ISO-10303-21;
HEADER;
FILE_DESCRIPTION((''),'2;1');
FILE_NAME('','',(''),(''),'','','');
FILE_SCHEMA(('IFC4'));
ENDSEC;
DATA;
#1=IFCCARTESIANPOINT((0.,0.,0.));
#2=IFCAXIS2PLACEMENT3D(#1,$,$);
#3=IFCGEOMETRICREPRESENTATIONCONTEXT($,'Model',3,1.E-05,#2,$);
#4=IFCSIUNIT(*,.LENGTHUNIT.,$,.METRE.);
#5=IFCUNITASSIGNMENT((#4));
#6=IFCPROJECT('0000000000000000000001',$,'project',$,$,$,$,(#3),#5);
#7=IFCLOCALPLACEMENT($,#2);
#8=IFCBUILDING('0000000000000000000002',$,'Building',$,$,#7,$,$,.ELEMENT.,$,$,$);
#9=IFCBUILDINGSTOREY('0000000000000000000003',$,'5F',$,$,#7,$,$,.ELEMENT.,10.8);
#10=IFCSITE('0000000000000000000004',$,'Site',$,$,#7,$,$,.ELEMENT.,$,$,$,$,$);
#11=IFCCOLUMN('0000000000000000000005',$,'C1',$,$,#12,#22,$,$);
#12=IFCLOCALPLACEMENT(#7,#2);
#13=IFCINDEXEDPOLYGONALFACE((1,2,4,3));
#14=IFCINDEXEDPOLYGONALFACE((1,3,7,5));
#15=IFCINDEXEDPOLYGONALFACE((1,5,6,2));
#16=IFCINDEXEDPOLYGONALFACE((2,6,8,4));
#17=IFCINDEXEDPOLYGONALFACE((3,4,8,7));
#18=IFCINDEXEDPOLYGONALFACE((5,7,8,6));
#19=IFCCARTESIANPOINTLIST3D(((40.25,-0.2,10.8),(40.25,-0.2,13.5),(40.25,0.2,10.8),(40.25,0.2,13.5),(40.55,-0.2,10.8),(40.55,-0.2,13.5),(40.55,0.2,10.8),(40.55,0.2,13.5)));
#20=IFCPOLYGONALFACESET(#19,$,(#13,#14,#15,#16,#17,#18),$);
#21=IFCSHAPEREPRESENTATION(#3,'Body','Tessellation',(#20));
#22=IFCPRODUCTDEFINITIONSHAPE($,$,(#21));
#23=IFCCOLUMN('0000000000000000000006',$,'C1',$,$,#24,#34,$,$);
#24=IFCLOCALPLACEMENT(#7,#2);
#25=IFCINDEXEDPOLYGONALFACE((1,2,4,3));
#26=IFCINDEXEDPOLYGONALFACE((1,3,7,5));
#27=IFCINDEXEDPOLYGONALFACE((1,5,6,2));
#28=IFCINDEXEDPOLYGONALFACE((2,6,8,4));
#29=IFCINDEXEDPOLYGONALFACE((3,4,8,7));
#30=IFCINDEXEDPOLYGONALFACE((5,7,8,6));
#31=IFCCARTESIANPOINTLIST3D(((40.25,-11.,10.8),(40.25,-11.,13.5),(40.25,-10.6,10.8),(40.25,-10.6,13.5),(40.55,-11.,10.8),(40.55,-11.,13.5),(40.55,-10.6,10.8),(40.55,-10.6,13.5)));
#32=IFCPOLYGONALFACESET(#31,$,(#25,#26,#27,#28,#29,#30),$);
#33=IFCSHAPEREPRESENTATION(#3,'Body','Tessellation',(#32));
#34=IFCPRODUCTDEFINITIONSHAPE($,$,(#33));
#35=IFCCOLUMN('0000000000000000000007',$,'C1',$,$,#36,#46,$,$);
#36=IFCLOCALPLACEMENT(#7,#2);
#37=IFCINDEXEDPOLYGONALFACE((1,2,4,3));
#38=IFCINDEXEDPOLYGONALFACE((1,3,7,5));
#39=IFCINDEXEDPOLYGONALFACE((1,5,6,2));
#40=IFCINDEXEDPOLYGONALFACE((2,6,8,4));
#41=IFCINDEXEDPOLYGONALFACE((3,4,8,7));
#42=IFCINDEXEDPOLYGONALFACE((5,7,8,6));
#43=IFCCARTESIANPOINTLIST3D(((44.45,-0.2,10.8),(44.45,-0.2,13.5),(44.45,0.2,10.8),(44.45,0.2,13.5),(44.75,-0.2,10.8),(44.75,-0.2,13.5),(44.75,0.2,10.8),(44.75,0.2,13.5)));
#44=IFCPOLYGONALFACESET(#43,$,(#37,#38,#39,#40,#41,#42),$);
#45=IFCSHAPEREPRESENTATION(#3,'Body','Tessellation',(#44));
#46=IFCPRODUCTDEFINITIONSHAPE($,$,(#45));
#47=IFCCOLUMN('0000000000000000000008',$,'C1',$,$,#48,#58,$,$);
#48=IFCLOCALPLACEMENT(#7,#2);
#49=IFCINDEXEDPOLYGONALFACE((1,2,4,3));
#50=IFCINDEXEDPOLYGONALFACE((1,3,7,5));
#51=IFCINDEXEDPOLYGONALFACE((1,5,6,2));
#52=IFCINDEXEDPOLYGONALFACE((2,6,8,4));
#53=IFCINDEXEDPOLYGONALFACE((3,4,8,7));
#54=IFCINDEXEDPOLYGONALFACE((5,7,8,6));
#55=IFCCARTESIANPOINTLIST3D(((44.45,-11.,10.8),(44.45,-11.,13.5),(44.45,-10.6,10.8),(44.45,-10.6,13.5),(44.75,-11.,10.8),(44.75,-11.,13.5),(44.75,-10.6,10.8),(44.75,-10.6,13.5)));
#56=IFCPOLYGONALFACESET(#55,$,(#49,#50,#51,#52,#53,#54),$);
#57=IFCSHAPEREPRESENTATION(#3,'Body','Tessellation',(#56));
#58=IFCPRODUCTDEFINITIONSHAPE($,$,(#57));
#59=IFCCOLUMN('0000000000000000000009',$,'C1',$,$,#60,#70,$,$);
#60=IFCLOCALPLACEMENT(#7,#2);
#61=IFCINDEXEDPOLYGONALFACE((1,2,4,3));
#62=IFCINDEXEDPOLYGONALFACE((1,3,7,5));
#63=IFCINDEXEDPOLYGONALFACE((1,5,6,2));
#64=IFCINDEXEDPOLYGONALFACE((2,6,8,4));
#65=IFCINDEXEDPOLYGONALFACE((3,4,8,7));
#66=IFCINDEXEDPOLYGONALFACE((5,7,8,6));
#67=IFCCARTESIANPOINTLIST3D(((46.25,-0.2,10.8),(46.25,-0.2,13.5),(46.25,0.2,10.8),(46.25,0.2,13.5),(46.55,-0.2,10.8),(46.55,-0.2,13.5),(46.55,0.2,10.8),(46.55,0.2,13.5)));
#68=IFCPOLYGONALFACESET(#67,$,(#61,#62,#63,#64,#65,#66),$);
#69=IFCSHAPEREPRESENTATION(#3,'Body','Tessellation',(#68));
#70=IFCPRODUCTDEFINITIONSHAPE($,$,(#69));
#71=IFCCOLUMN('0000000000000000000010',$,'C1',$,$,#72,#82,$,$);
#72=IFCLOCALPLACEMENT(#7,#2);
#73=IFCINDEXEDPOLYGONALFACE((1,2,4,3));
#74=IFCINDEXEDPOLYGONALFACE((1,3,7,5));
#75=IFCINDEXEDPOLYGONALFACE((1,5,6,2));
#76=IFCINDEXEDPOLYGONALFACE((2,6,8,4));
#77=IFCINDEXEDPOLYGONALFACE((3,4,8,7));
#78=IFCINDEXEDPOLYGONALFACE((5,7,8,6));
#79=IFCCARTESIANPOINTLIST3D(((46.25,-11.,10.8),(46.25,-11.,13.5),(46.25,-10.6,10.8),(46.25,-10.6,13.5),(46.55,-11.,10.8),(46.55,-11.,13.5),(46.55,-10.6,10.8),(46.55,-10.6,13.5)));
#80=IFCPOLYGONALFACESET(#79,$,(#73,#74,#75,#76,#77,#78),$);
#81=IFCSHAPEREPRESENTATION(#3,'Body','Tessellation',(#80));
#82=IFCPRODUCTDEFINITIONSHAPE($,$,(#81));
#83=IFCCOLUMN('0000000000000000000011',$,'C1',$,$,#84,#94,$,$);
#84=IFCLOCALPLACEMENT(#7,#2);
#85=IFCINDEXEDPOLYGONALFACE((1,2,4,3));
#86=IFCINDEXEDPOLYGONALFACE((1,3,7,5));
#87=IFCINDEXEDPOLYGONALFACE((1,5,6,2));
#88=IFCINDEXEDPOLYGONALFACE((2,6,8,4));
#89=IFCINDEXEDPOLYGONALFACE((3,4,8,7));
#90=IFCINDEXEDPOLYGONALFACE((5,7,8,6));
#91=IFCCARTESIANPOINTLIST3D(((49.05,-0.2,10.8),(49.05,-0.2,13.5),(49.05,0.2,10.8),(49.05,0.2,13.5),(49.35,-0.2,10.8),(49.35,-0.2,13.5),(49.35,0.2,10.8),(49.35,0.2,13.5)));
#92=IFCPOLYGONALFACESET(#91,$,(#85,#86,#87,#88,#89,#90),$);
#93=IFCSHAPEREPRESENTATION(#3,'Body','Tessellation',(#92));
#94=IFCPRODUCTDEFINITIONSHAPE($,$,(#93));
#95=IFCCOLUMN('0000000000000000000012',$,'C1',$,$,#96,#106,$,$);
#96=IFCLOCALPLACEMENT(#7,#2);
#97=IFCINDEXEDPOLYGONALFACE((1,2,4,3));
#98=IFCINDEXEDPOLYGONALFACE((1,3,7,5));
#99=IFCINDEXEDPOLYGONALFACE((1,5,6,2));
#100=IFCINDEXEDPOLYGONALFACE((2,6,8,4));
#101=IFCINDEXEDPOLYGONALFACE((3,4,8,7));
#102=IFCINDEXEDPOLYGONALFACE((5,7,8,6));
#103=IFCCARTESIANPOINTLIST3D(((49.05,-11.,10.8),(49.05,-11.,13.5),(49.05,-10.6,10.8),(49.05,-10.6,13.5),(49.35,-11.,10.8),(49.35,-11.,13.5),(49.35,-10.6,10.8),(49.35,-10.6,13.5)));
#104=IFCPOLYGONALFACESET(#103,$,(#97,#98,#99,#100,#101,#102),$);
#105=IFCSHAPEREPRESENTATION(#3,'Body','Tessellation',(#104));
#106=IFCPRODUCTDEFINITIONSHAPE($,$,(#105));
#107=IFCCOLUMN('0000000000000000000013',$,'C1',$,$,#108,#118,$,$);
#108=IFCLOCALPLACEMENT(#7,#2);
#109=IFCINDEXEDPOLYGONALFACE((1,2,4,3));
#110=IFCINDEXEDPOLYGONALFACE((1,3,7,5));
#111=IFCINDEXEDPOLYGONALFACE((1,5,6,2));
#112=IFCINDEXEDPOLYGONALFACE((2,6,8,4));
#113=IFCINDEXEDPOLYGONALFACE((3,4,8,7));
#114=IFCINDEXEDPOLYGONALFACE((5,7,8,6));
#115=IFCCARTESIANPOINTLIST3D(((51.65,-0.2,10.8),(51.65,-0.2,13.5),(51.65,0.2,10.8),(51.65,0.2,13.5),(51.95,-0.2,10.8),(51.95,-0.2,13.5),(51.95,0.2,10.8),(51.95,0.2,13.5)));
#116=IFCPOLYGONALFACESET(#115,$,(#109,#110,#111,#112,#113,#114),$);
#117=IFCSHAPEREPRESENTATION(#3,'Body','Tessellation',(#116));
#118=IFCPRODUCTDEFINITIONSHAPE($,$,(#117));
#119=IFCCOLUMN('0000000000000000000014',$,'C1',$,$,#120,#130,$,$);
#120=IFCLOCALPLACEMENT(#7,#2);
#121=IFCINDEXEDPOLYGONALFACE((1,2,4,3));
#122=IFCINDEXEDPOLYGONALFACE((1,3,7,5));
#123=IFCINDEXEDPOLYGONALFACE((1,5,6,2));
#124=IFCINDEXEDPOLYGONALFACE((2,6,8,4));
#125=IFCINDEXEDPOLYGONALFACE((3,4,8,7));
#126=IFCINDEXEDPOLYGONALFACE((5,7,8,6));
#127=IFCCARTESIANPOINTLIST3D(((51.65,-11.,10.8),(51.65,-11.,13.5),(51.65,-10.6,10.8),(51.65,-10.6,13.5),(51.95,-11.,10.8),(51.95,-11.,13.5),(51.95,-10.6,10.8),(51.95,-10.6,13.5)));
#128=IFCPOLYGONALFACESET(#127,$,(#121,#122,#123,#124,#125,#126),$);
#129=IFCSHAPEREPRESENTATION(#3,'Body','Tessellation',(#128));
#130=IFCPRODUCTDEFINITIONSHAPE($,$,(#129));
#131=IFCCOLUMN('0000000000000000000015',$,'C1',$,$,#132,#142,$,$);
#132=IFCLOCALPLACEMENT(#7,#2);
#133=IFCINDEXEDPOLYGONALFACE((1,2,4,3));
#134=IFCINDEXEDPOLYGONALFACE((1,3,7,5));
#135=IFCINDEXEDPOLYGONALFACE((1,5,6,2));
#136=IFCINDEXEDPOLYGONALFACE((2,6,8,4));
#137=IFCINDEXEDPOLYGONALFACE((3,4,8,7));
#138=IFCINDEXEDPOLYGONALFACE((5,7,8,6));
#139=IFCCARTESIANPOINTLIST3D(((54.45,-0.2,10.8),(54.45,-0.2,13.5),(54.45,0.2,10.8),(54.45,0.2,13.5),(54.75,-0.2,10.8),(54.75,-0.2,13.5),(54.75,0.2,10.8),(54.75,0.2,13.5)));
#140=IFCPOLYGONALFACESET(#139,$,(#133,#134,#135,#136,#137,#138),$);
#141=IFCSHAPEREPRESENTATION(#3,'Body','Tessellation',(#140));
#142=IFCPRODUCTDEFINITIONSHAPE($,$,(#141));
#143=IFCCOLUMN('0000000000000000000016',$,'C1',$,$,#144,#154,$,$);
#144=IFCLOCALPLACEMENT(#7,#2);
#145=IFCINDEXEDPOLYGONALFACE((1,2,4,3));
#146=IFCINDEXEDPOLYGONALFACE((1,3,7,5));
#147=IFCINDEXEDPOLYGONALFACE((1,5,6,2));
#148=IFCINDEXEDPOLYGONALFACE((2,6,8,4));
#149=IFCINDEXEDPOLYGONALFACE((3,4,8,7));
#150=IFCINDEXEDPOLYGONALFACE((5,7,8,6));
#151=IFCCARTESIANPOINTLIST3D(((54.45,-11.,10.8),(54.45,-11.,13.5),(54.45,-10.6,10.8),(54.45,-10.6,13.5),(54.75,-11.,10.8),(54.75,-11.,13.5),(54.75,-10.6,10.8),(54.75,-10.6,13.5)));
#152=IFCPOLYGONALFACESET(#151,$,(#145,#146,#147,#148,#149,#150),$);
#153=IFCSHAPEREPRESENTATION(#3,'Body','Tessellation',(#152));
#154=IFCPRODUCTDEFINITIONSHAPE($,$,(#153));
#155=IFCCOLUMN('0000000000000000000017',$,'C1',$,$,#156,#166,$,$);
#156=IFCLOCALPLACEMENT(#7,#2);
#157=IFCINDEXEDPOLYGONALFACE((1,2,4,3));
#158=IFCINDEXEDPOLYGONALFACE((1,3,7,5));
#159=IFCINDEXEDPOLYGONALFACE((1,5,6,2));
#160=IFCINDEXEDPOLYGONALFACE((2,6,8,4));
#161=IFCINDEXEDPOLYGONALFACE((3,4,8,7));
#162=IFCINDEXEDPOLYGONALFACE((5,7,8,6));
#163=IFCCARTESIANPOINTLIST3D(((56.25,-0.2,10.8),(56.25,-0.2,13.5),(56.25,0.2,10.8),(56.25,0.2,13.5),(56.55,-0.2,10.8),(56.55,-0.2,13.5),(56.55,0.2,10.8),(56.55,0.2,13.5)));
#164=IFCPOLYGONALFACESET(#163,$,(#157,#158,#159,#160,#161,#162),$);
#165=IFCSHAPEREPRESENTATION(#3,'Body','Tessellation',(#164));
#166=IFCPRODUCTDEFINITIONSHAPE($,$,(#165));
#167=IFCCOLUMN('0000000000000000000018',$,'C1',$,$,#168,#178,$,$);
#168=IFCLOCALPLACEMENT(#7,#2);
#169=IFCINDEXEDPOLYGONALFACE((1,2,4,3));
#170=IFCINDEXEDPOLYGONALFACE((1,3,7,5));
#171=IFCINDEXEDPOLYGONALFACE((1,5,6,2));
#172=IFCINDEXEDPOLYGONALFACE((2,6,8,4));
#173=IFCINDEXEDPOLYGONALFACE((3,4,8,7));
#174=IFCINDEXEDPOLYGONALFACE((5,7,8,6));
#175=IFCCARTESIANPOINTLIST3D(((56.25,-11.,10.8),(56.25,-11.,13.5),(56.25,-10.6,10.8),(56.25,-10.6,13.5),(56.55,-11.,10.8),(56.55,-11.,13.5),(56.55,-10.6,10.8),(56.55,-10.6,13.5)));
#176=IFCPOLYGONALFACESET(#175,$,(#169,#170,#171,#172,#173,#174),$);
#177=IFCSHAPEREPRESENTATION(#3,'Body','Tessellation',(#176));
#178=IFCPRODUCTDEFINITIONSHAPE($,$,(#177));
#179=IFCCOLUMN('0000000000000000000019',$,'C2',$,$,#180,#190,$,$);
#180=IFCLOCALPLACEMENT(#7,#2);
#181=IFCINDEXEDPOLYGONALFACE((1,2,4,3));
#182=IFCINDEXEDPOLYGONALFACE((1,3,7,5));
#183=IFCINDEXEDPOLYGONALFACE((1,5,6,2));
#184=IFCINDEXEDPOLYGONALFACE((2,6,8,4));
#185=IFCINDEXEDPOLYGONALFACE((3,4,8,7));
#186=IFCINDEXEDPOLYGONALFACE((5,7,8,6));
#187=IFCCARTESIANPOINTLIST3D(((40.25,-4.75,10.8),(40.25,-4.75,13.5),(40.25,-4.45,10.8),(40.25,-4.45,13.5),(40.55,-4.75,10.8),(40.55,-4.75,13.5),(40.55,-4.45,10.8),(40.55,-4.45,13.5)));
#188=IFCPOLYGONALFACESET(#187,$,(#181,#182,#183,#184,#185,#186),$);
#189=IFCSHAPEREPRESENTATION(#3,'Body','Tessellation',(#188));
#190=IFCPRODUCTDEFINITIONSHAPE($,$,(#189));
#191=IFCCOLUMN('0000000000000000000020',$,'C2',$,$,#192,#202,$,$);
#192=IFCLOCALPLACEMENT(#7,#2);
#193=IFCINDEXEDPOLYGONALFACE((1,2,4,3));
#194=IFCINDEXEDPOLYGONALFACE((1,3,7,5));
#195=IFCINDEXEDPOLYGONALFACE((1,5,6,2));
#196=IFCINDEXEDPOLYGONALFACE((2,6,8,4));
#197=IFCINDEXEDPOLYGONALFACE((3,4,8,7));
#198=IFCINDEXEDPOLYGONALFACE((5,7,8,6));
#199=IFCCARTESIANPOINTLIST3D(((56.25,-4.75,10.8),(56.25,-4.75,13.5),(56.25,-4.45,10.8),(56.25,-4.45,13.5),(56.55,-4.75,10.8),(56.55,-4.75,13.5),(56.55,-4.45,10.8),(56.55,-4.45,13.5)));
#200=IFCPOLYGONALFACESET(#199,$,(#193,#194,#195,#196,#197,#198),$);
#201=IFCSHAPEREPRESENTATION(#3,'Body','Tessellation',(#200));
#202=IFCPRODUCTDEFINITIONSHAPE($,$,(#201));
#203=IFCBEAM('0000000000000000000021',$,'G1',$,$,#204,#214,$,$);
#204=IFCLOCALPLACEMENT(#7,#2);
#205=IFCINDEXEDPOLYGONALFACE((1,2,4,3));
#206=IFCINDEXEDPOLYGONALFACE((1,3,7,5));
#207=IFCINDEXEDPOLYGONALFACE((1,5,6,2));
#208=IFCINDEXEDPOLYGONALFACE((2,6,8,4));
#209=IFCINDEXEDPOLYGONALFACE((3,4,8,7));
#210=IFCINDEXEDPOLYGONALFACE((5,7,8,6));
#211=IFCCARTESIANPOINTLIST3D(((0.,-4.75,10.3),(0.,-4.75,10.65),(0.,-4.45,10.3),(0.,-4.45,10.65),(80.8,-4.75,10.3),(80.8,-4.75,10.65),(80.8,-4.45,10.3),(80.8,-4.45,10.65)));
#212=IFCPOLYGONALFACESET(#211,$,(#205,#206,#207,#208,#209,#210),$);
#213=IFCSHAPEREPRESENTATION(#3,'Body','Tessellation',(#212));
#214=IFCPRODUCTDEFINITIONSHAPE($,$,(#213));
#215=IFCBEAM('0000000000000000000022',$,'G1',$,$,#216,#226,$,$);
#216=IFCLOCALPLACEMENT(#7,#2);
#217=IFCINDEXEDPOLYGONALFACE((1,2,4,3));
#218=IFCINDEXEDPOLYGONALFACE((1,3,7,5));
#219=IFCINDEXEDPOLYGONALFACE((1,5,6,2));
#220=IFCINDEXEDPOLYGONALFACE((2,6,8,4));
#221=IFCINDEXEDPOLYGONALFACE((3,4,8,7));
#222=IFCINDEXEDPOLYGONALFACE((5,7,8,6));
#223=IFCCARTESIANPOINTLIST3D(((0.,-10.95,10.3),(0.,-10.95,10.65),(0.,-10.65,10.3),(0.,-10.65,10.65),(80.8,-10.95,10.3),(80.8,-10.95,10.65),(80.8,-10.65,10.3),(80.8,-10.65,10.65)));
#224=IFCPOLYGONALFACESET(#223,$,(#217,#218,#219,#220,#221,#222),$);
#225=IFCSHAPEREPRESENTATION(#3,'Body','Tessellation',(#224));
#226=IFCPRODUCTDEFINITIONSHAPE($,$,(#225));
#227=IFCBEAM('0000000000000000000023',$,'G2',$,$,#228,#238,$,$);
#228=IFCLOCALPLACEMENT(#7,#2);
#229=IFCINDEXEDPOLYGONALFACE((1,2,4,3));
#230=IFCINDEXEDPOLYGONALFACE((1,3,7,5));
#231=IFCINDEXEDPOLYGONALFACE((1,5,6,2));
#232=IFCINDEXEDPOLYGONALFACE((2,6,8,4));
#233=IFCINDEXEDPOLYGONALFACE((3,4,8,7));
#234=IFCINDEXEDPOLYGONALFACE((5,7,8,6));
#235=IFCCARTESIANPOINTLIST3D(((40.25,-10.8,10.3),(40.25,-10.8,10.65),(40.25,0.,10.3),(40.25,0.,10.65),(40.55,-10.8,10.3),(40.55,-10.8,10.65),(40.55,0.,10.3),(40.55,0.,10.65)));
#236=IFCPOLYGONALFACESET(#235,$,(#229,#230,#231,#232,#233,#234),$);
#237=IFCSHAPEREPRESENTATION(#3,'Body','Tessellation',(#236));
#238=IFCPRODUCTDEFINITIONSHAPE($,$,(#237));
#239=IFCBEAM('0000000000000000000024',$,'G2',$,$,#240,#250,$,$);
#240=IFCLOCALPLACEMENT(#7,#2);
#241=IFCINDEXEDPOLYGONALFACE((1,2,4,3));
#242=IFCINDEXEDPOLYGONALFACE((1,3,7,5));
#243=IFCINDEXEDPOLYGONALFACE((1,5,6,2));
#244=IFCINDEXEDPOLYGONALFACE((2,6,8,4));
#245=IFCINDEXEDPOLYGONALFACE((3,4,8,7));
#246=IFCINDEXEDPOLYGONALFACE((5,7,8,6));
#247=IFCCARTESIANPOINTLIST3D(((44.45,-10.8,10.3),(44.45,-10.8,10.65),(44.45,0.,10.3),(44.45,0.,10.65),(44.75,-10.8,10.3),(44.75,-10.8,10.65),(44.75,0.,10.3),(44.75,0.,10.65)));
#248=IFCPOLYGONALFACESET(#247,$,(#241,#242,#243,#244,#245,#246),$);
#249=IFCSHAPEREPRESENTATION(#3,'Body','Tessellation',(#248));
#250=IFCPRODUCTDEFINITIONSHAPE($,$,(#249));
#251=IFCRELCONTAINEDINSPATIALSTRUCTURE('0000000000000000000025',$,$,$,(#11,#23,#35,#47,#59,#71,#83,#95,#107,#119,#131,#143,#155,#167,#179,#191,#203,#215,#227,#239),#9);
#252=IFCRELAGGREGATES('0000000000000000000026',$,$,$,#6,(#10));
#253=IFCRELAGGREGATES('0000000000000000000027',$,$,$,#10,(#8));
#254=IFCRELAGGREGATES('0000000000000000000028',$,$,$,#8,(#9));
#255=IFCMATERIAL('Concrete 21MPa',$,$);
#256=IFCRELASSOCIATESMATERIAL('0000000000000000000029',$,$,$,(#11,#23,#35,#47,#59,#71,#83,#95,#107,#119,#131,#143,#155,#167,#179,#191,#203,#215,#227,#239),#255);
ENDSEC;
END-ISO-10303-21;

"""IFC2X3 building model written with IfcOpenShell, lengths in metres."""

from ifc_helpers import new_model, si_unit, frame, origin, origin_2d, place, context, project, spatial, rectangle, extrude, material, element, save


model = new_model("IFC2X3")

# Units and contexts
model_context = context("Model", 3, precision=1e-05, world=origin())
ifc_project = project(units=[si_unit("LENGTHUNIT", "METRE")], contexts=[model_context])

# Site, building, storey
placement = place(None, origin())
site = spatial("IfcSite", under=ifc_project, at=placement, Name="Site", CompositionType="ELEMENT")
building = spatial("IfcBuilding", under=site, at=placement, Name="Building", CompositionType="ELEMENT")
storey = spatial("IfcBuildingStorey", under=building, at=placement, Name="5F", CompositionType="ELEMENT", Elevation=10.8)

# Columns
ifc_material = material(Name="Concrete 21MPa")
for number, where, name in (
    (1, (40.4, 0.0, 10.8), "C1"),
    (2, (40.4, -10.8, 10.8), "C1"),
    (3, (44.6, 0.0, 10.8), "C1"),
    (4, (44.6, -10.8, 10.8), "C1"),
    (5, (46.4, 0.0, 10.8), "C1"),
    (6, (46.4, -10.8, 10.8), "C1"),
    (7, (49.2, 0.0, 10.8), "C1"),
    (8, (49.2, -10.8, 10.8), "C1"),
    (9, (51.8, 0.0, 10.8), "C1"),
    (10, (51.8, -10.8, 10.8), "C1"),
    (11, (54.6, 0.0, 10.8), "C1"),
    (12, (54.6, -10.8, 10.8), "C1"),
    (13, (56.4, 0.0, 10.8), "C1"),
    (14, (56.4, -10.8, 10.8), "C1"),
):
    element("IfcColumn", number, at=place(None, frame(where)), inside=storey, material=ifc_material, Name=name, context=model_context, shape_type="SweptSolid", body=[
        extrude(rectangle(XDim=0.3, YDim=0.4, at=origin_2d()), origin(), (0.0, 0.0, 1.0), 2.7),
    ])
for number, where, name in (
    (15, (40.4, -4.6, 10.8), "C2"),
    (16, (56.4, -4.6, 10.8), "C2"),
):
    element("IfcColumn", number, at=place(None, frame(where)), inside=storey, material=ifc_material, Name=name, context=model_context, shape_type="SweptSolid", body=[
        extrude(rectangle(XDim=0.3, YDim=0.3, at=origin_2d()), origin(), (0.0, 0.0, 1.0), 2.7),
    ])

# Beams
for number, where, name in (
    (17, (40.4, -4.6, 10.3), "G1"),
    (18, (40.4, -10.8, 10.3), "G1"),
):
    element("IfcBeam", number, at=place(None, frame(where)), inside=storey, material=ifc_material, Name=name, context=model_context, shape_type="SweptSolid", body=[
        extrude(rectangle(XDim=80.8, YDim=0.3, at=origin_2d()), origin(), (0.0, 0.0, 1.0), 0.35),
    ])
for number, where, name in (
    (19, (40.4, -5.4, 10.3), "G2"),
    (20, (44.6, -5.4, 10.3), "G2"),
):
    element("IfcBeam", number, at=place(None, frame(where)), inside=storey, material=ifc_material, Name=name, context=model_context, shape_type="SweptSolid", body=[
        extrude(rectangle(XDim=0.3, YDim=10.8, at=origin_2d()), origin(), (0.0, 0.0, 1.0), 0.35),
    ])

save(model, "model.ifc")
